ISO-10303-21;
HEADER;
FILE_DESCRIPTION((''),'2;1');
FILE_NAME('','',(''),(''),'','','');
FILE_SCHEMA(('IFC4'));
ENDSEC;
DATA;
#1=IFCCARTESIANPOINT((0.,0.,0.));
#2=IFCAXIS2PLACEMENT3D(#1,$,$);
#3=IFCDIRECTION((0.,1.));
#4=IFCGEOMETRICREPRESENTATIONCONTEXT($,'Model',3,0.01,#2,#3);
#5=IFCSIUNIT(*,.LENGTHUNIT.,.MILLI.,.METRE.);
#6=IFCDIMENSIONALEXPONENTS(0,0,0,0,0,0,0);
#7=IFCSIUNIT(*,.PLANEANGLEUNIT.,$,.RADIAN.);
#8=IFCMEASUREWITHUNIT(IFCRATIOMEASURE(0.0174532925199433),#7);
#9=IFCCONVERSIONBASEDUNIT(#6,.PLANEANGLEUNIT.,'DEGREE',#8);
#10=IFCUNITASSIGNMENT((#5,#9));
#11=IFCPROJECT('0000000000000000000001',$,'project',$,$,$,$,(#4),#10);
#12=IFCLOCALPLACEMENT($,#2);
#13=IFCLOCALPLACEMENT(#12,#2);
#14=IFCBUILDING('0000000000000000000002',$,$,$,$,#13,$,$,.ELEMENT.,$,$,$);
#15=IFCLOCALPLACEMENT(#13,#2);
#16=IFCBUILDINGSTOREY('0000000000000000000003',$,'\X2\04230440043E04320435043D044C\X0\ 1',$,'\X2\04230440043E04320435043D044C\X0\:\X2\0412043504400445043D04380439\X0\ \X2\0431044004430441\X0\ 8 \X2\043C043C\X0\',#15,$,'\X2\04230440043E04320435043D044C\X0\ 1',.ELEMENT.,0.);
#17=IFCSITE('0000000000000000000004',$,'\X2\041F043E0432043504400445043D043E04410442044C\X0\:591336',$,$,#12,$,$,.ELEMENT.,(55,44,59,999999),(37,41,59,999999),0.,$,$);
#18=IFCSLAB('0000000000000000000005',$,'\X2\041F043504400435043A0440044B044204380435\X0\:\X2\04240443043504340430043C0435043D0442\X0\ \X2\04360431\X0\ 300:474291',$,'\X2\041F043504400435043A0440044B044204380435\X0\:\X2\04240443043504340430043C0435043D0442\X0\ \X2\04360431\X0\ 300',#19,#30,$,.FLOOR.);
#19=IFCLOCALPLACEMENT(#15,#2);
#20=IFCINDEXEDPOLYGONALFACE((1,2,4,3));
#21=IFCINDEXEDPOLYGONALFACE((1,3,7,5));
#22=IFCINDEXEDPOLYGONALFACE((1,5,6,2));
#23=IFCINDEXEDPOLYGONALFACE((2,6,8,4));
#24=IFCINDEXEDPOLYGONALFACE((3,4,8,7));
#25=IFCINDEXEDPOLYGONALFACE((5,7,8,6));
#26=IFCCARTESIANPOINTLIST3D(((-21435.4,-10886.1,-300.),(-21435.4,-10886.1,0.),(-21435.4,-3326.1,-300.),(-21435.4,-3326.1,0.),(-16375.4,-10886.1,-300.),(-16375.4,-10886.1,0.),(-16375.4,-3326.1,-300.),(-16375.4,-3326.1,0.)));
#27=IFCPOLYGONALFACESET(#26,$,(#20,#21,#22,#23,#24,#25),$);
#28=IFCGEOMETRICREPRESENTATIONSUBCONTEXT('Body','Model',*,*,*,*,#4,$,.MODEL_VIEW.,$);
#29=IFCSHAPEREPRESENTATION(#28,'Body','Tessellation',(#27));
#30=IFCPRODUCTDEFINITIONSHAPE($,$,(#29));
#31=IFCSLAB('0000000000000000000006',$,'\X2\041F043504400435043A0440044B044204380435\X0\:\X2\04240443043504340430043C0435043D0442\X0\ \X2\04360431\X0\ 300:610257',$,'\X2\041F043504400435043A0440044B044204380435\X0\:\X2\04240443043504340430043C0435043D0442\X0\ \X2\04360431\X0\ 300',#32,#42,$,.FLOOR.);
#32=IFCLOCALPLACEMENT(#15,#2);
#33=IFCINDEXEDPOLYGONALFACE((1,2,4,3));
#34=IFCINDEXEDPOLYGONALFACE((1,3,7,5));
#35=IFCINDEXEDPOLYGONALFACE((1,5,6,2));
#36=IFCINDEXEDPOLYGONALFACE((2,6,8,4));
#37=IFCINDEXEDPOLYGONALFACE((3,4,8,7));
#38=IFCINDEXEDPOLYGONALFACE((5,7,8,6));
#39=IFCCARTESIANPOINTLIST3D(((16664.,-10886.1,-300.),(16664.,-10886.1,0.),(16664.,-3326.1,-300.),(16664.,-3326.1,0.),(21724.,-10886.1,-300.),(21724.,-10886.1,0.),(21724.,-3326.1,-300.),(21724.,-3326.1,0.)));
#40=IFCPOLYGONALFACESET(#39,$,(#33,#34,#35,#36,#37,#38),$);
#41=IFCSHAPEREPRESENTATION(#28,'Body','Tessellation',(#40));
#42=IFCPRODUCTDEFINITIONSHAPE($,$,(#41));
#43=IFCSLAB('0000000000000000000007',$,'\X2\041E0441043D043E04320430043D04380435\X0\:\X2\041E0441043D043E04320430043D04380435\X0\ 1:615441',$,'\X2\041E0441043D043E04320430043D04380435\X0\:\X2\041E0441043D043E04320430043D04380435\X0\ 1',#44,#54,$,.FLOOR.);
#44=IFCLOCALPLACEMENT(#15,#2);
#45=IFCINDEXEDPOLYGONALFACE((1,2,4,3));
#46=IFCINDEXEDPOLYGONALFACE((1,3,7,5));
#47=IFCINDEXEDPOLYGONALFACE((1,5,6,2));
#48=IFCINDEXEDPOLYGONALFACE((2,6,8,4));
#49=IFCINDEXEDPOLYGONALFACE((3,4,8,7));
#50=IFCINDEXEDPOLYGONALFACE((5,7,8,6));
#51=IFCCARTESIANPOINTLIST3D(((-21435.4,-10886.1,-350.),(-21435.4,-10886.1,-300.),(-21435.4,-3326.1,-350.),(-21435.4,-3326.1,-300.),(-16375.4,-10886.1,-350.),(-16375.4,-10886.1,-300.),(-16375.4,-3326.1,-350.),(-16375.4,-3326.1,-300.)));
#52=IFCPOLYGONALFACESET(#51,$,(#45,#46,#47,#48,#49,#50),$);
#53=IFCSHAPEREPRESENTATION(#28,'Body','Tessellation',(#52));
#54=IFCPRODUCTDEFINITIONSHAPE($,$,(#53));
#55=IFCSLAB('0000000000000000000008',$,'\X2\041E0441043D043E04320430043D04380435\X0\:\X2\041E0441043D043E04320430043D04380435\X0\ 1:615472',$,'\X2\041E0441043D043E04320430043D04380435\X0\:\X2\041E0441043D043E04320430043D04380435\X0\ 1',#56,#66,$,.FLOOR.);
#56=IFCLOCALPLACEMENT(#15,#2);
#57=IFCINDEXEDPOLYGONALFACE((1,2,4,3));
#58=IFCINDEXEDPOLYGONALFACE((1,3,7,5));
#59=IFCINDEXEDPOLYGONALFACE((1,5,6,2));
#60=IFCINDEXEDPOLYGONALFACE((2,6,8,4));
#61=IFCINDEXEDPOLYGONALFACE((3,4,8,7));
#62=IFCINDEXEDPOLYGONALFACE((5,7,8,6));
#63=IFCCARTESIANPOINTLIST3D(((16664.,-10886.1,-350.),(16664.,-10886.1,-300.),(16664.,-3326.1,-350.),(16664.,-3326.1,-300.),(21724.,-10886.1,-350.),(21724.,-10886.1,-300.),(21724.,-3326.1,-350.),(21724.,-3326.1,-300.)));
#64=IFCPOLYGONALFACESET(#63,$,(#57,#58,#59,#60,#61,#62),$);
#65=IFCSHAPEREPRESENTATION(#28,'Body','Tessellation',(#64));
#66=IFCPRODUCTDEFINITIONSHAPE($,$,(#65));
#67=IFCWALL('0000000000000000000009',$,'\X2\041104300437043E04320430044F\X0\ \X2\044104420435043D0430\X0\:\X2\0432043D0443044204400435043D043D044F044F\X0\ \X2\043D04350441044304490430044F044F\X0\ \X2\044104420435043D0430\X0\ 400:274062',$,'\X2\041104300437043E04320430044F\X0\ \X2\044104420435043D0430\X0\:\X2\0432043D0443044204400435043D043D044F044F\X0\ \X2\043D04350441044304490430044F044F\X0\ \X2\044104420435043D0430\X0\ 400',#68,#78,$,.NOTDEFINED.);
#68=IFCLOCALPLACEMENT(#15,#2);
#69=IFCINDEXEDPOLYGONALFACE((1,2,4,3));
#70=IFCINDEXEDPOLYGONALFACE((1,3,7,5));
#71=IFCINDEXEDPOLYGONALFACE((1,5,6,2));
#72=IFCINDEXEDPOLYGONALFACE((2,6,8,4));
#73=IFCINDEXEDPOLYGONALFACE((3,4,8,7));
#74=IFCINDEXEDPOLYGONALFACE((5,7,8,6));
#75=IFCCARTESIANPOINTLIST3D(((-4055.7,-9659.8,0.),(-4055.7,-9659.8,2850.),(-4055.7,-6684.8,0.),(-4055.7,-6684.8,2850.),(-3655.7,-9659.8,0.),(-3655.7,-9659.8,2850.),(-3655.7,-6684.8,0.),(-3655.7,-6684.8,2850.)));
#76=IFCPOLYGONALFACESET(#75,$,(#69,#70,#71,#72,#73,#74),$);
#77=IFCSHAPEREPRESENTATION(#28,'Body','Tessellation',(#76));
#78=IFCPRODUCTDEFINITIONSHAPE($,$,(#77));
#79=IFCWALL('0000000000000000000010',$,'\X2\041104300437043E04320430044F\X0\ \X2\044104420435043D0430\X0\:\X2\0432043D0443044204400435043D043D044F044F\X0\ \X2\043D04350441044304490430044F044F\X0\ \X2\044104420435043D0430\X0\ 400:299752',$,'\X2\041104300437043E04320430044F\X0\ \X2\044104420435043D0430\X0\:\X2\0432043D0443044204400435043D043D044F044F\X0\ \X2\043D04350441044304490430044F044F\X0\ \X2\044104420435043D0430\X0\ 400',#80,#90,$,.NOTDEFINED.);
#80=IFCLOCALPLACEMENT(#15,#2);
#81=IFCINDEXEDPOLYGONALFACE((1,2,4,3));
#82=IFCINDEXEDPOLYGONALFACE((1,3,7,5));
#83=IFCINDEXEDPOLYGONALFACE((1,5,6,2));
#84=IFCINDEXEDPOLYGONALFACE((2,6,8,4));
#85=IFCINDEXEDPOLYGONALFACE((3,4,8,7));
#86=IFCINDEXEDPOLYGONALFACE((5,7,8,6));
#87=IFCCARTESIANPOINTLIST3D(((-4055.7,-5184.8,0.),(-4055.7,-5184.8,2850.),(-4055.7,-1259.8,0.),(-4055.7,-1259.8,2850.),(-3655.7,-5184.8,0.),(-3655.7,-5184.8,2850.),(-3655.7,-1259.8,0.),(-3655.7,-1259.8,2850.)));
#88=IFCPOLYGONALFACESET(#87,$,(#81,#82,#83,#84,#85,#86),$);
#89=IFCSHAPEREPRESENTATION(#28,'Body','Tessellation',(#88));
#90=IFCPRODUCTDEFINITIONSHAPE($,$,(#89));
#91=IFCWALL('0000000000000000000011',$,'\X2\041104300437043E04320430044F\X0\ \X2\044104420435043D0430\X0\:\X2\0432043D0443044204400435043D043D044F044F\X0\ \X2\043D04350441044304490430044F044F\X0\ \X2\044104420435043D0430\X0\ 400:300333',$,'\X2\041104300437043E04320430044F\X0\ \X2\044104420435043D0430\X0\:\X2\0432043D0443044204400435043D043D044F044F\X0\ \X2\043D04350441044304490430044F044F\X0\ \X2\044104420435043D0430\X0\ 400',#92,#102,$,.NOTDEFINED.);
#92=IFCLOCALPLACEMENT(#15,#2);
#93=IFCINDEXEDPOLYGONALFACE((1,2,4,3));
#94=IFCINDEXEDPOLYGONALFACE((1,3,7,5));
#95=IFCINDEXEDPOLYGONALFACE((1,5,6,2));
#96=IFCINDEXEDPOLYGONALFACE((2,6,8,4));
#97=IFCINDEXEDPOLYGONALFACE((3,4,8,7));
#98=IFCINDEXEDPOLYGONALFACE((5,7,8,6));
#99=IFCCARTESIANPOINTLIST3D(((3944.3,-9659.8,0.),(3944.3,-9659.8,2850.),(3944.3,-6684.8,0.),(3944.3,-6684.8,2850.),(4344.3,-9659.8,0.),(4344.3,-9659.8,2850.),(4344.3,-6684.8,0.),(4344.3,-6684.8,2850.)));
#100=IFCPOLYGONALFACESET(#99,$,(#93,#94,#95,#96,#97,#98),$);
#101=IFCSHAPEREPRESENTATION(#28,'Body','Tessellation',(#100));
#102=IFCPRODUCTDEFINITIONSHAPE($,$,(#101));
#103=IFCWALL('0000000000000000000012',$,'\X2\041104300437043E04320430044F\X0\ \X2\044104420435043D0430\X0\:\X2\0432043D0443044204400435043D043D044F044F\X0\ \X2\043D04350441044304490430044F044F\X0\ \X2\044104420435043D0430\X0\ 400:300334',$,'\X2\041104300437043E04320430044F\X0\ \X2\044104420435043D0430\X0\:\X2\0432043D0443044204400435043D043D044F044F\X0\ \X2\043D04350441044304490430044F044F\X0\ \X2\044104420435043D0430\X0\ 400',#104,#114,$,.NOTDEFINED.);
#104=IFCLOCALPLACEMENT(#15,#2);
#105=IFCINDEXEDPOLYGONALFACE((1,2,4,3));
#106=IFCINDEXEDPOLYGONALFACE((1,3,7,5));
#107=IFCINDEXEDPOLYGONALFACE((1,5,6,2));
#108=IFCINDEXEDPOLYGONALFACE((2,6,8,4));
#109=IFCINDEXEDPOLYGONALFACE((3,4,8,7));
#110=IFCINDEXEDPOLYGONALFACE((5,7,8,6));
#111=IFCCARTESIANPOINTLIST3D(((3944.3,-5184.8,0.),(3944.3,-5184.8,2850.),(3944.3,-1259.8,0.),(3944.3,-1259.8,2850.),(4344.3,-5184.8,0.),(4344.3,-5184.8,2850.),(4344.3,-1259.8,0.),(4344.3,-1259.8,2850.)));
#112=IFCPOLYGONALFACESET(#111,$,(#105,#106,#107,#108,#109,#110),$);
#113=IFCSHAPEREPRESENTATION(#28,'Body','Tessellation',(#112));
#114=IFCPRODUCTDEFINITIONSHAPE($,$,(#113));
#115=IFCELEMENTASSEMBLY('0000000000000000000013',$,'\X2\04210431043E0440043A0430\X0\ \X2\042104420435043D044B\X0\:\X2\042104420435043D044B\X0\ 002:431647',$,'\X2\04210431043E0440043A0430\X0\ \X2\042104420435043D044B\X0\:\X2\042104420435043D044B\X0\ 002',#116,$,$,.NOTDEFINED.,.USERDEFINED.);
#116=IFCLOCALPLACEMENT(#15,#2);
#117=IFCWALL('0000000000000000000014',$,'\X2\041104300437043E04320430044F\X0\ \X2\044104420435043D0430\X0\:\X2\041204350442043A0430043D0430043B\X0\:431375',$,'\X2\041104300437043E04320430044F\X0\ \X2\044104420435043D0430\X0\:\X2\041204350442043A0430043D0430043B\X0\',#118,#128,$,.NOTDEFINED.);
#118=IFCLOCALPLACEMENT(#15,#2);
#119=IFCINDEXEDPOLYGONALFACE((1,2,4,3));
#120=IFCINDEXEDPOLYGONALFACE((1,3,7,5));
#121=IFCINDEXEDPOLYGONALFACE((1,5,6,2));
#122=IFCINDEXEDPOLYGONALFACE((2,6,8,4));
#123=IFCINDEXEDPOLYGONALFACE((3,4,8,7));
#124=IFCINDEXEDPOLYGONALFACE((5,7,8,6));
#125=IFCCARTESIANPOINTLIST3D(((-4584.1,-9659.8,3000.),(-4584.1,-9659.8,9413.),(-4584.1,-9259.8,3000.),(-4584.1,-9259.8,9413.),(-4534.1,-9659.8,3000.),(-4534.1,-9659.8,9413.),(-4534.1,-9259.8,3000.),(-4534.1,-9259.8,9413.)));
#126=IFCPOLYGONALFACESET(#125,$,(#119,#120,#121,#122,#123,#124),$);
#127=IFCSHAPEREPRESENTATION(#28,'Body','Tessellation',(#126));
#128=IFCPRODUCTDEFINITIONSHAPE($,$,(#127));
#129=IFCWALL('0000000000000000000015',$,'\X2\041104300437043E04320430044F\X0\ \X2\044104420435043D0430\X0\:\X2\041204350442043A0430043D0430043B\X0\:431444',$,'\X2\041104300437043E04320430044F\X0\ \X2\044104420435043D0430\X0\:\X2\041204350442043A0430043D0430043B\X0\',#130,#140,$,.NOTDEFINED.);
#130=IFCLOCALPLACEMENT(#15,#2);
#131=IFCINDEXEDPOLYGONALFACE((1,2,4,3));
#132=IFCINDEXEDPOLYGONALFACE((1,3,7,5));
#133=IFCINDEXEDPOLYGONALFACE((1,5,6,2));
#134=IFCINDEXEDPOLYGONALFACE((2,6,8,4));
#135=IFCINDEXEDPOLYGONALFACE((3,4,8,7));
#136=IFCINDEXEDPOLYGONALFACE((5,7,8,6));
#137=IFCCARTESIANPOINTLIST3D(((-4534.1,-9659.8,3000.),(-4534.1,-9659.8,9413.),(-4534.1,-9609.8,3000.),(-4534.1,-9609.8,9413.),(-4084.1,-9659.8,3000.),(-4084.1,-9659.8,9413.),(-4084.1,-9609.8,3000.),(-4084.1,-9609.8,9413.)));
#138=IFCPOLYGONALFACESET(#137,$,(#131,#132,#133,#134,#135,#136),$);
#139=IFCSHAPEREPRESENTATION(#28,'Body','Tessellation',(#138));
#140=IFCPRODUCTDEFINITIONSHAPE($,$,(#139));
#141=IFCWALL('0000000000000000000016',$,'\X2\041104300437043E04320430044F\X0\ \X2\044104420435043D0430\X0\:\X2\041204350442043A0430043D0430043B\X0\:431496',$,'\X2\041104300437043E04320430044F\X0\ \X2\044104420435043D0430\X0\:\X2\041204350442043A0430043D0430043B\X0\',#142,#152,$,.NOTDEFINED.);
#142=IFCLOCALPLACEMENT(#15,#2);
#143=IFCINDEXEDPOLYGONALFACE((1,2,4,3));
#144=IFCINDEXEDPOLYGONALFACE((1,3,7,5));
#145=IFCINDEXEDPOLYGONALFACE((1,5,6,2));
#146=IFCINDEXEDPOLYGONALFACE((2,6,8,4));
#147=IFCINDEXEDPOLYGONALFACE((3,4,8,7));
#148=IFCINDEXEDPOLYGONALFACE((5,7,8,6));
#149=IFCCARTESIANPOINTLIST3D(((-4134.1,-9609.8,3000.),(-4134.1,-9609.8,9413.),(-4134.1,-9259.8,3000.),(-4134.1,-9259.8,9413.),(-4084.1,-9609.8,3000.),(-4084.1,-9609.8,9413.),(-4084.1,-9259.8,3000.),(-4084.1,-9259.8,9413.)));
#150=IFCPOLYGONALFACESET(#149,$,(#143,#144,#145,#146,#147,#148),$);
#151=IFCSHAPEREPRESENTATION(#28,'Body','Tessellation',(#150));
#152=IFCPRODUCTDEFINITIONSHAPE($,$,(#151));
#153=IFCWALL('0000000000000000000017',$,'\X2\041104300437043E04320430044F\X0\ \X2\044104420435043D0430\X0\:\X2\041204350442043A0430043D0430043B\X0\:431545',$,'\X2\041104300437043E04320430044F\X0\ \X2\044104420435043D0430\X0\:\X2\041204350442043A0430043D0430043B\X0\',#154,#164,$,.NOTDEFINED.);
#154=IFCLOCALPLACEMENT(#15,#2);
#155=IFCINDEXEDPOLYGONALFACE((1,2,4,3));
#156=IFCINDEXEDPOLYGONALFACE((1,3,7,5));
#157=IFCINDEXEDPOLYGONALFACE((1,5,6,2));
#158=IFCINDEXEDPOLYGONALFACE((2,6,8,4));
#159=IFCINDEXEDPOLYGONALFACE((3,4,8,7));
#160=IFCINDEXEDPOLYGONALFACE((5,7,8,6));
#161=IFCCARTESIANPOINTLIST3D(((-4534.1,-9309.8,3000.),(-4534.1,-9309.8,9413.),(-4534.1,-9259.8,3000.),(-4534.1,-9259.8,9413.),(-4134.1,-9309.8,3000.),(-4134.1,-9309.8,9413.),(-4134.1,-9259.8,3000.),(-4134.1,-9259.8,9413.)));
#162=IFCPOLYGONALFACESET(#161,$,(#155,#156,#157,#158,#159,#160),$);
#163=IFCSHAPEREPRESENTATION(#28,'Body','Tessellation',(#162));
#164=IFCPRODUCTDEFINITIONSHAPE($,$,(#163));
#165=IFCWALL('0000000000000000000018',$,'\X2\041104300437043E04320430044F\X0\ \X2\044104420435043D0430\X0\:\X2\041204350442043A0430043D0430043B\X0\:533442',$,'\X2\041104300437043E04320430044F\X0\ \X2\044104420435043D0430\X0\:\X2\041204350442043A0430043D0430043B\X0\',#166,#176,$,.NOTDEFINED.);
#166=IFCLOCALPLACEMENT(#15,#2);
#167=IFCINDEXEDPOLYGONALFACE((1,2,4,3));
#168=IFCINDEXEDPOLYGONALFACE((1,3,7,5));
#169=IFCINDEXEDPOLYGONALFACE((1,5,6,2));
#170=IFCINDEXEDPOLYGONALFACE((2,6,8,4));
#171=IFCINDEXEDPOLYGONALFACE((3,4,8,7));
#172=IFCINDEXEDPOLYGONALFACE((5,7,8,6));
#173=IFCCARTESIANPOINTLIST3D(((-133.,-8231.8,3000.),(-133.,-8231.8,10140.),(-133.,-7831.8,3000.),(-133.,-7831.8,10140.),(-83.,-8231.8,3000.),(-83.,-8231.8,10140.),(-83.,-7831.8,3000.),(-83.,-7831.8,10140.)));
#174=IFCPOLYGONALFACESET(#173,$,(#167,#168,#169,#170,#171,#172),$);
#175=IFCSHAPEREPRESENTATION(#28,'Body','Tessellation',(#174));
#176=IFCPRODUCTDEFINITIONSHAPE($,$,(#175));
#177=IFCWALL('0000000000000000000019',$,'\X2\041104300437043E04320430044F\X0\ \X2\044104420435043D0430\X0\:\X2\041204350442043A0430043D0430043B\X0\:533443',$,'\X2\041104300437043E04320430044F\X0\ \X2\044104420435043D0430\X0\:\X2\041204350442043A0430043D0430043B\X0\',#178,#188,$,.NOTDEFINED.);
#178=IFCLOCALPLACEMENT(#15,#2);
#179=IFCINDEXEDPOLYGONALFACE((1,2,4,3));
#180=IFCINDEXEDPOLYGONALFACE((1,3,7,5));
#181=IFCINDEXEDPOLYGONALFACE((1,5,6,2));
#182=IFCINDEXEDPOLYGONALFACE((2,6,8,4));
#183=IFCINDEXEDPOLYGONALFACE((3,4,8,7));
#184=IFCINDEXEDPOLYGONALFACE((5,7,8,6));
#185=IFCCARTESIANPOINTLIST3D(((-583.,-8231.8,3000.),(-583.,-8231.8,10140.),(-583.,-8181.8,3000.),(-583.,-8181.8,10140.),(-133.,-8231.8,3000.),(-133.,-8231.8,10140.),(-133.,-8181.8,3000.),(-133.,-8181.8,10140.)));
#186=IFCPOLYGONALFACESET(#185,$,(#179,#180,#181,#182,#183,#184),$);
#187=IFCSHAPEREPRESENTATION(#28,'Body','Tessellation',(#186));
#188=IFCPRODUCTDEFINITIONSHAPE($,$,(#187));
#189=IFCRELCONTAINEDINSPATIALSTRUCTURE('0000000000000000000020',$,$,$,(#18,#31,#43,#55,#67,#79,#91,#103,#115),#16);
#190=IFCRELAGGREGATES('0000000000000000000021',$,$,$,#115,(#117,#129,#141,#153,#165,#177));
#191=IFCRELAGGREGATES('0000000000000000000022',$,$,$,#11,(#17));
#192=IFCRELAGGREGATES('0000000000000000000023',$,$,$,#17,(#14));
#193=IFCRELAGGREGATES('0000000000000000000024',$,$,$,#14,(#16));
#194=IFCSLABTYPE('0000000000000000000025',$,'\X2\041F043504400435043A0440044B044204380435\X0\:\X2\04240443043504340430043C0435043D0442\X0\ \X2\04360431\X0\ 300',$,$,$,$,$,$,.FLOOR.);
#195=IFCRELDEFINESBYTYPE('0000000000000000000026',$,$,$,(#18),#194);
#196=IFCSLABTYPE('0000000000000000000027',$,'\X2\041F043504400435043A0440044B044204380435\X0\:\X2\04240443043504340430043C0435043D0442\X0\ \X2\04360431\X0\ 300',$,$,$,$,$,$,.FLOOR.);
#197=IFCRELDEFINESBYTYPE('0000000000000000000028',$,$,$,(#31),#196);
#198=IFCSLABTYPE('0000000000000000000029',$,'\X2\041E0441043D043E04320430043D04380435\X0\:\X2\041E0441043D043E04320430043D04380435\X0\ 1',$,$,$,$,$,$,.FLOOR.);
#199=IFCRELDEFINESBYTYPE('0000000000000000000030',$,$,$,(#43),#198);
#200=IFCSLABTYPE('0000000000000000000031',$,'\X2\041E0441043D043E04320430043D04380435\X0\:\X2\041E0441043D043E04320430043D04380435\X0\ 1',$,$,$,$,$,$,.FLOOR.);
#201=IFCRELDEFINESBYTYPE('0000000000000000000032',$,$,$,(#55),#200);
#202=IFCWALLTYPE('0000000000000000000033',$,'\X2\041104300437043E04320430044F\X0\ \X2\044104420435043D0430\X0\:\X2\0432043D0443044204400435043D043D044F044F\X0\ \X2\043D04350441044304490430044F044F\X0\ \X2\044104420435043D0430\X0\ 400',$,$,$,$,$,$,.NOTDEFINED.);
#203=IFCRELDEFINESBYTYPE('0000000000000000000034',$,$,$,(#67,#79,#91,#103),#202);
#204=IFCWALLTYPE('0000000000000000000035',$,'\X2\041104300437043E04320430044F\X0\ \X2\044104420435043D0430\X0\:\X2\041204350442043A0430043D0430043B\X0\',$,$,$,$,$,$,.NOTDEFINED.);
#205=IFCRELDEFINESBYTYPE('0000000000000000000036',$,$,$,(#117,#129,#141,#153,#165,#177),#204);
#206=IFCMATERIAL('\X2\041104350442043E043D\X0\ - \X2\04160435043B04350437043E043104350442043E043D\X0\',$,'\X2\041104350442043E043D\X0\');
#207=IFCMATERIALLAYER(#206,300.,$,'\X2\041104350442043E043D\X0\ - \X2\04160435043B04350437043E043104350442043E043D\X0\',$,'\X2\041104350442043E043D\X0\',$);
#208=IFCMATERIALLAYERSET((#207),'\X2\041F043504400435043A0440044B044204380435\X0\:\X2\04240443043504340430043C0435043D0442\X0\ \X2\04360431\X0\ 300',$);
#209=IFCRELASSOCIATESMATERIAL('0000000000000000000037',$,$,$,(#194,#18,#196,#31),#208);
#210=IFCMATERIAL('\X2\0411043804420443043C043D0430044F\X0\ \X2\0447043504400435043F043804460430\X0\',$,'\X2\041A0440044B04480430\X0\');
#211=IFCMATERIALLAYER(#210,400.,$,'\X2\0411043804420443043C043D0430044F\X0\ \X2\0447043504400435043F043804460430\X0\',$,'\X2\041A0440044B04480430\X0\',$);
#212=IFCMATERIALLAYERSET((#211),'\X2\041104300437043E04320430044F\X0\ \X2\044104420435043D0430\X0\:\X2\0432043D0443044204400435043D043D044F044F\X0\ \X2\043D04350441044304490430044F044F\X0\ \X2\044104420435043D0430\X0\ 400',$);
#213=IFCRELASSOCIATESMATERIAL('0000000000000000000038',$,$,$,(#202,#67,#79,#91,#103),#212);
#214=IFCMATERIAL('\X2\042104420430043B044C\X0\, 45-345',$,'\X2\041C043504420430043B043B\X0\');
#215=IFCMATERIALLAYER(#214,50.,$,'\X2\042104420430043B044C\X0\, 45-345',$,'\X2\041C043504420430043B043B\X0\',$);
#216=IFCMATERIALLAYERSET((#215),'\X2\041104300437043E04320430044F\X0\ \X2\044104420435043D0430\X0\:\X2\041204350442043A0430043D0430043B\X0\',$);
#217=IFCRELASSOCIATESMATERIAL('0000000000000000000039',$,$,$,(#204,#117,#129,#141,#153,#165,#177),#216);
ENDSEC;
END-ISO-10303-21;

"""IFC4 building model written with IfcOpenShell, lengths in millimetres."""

from ifc_helpers import new_model, entity, si_unit, converted_unit, direction, frame, origin, place, context, subcontext, project, spatial, indexed_curve, outline, extrude, material, layer, layer_set, type_object, element, aggregate, save


model = new_model("IFC4")

# Units and contexts
model_context = context("Model", 3, precision=0.01, world=origin(), true_north=direction((0.0, 1.0)))
body_context = subcontext(model_context, "Body", "Model", "MODEL_VIEW")
ifc_project = project(units=[si_unit("LENGTHUNIT", "METRE", prefix="MILLI"), converted_unit("PLANEANGLEUNIT", "DEGREE", entity("IfcRatioMeasure", 0.0174532925199433), si_unit("PLANEANGLEUNIT", "RADIAN"), dimensions=[0, 0, 0, 0, 0, 0, 0])], contexts=[model_context])

# Site, building, storey
site_placement = place(None, origin())
site = spatial("IfcSite", under=ifc_project, at=site_placement, Name="Поверхность:591336", CompositionType="ELEMENT", RefLatitude=(55, 44, 59, 999999), RefLongitude=(37, 41, 59, 999999), RefElevation=0.0)
building_placement = place(site_placement, origin())
building = spatial("IfcBuilding", under=site, at=building_placement, CompositionType="ELEMENT")
storey_placement = place(building_placement, origin())
storey = spatial("IfcBuildingStorey", under=building, at=storey_placement, Name="Уровень 1", ObjectType="Уровень:Верхний брус 8 мм", LongName="Уровень 1", CompositionType="ELEMENT", Elevation=0.0)

# Slabs
ifc_material_1 = material(Name="Бетон - Железобетон", Category="Бетон")
ifc_layer_1 = layer(ifc_material_1, 300.0, Name="Бетон - Железобетон", Category="Бетон")
ifc_layer_set_1 = layer_set([ifc_layer_1], Name="Перекрытие:Фуедамент жб 300")
slab_type_1 = type_object("IfcSlabType", Name="Перекрытие:Фуедамент жб 300", PredefinedType="FLOOR", material=ifc_layer_set_1)
slab_1_placement = place(storey_placement, origin())
element("IfcSlab", 1, at=slab_1_placement, inside=storey, type_object=slab_type_1, material=ifc_layer_set_1, Name="Перекрытие:Фуедамент жб 300:474291", ObjectType="Перекрытие:Фуедамент жб 300", PredefinedType="FLOOR", context=body_context, shape_type="SweptSolid", body=[
    extrude(outline(indexed_curve([(-3780.0, -2530.0), (3780.0, -2530.0), (3780.0, 2530.0), (-3780.0, 2530.0), (-3780.0, -2530.0)], self_intersect=False)), frame((-18905.4, -7106.1, 0.0), z_axis=(0.0, 0.0, -1.0), x_axis=(0.0, 1.0, 0.0)), (0.0, 0.0, 1.0), 300.0),
])
slab_type_2 = type_object("IfcSlabType", Name="Перекрытие:Фуедамент жб 300", PredefinedType="FLOOR", material=ifc_layer_set_1)
slab_2_placement = place(storey_placement, origin())
element("IfcSlab", 2, at=slab_2_placement, inside=storey, type_object=slab_type_2, material=ifc_layer_set_1, Name="Перекрытие:Фуедамент жб 300:610257", ObjectType="Перекрытие:Фуедамент жб 300", PredefinedType="FLOOR", context=body_context, shape_type="SweptSolid", body=[
    extrude(outline(indexed_curve([(-3780.0, -2530.0), (3780.0, -2530.0), (3780.0, 2530.0), (-3780.0, 2530.0), (-3780.0, -2530.0)], self_intersect=False)), frame((19194.0, -7106.1, 0.0), z_axis=(0.0, 0.0, -1.0), x_axis=(0.0, 1.0, 0.0)), (0.0, 0.0, 1.0), 300.0),
])
slab_type_3 = type_object("IfcSlabType", Name="Основание:Основание 1", PredefinedType="FLOOR")
slab_3_placement = place(storey_placement, origin())
element("IfcSlab", 3, at=slab_3_placement, inside=storey, type_object=slab_type_3, Name="Основание:Основание 1:615441", ObjectType="Основание:Основание 1", PredefinedType="FLOOR", context=body_context, shape_type="SweptSolid", body=[
    extrude(outline(indexed_curve([(-3780.0, -2530.0), (3780.0, -2530.0), (3780.0, 2530.0), (-3780.0, 2530.0), (-3780.0, -2530.0)], self_intersect=False)), frame((-18905.4, -7106.1, -350.0), z_axis=(0.0, 0.0, 1.0), x_axis=(0.0, 1.0, 0.0)), (0.0, 0.0, 1.0), 50.0),
])
slab_type_4 = type_object("IfcSlabType", Name="Основание:Основание 1", PredefinedType="FLOOR")
slab_4_placement = place(storey_placement, origin())
element("IfcSlab", 4, at=slab_4_placement, inside=storey, type_object=slab_type_4, Name="Основание:Основание 1:615472", ObjectType="Основание:Основание 1", PredefinedType="FLOOR", context=body_context, shape_type="SweptSolid", body=[
    extrude(outline(indexed_curve([(-2530.0, -3780.0), (2530.0, -3780.0), (2530.0, 3780.0), (-2530.0, 3780.0), (-2530.0, -3780.0)], self_intersect=False)), frame((19194.0, -7106.1, -350.0), z_axis=(0.0, 0.0, 1.0), x_axis=(-1.0, 0.0, 0.0)), (0.0, 0.0, 1.0), 50.0),
])

# Walls
ifc_material_2 = material(Name="Битумная черепица", Category="Крыша")
ifc_layer_2 = layer(ifc_material_2, 400.0, Name="Битумная черепица", Category="Крыша")
ifc_layer_set_2 = layer_set([ifc_layer_2], Name="Базовая стена:внутренняя несущаяя стена 400")
wall_type_1 = type_object("IfcWallType", Name="Базовая стена:внутренняя несущаяя стена 400", PredefinedType="NOTDEFINED", material=ifc_layer_set_2)
wall_1_placement = place(storey_placement, frame((-3855.7, -9659.8, 0.0), z_axis=(0.0, 0.0, 1.0), x_axis=(0.0, 1.0, 0.0)))
element("IfcWall", 5, at=wall_1_placement, inside=storey, type_object=wall_type_1, material=ifc_layer_set_2, Name="Базовая стена:внутренняя несущаяя стена 400:274062", ObjectType="Базовая стена:внутренняя несущаяя стена 400", PredefinedType="NOTDEFINED", context=body_context, shape_type="SweptSolid", body=[
    extrude(outline(indexed_curve([(2975.0, 200.0), (0.0, 200.0), (0.0, -200.0), (2975.0, -200.0), (2975.0, 200.0)], self_intersect=False)), origin(), (0.0, 0.0, 1.0), 2850.0),
])
wall_2_placement = place(storey_placement, frame((-3855.7, -5184.8, 0.0), z_axis=(0.0, 0.0, 1.0), x_axis=(0.0, 1.0, 0.0)))
element("IfcWall", 6, at=wall_2_placement, inside=storey, type_object=wall_type_1, material=ifc_layer_set_2, Name="Базовая стена:внутренняя несущаяя стена 400:299752", ObjectType="Базовая стена:внутренняя несущаяя стена 400", PredefinedType="NOTDEFINED", context=body_context, shape_type="SweptSolid", body=[
    extrude(outline(indexed_curve([(3925.0, 200.0), (0.0, 200.0), (0.0, -200.0), (3925.0, -200.0), (3925.0, 200.0)], self_intersect=False)), origin(), (0.0, 0.0, 1.0), 2850.0),
])
wall_3_placement = place(storey_placement, frame((4144.3, -9659.8, 0.0), z_axis=(0.0, 0.0, 1.0), x_axis=(0.0, 1.0, 0.0)))
element("IfcWall", 7, at=wall_3_placement, inside=storey, type_object=wall_type_1, material=ifc_layer_set_2, Name="Базовая стена:внутренняя несущаяя стена 400:300333", ObjectType="Базовая стена:внутренняя несущаяя стена 400", PredefinedType="NOTDEFINED", context=body_context, shape_type="SweptSolid", body=[
    extrude(outline(indexed_curve([(2975.0, 200.0), (0.0, 200.0), (0.0, -200.0), (2975.0, -200.0), (2975.0, 200.0)], self_intersect=False)), origin(), (0.0, 0.0, 1.0), 2850.0),
])
wall_4_placement = place(storey_placement, frame((4144.3, -5184.8, 0.0), z_axis=(0.0, 0.0, 1.0), x_axis=(0.0, 1.0, 0.0)))
element("IfcWall", 8, at=wall_4_placement, inside=storey, type_object=wall_type_1, material=ifc_layer_set_2, Name="Базовая стена:внутренняя несущаяя стена 400:300334", ObjectType="Базовая стена:внутренняя несущаяя стена 400", PredefinedType="NOTDEFINED", context=body_context, shape_type="SweptSolid", body=[
    extrude(outline(indexed_curve([(3925.0, 200.0), (0.0, 200.0), (0.0, -200.0), (3925.0, -200.0), (3925.0, 200.0)], self_intersect=False)), origin(), (0.0, 0.0, 1.0), 2850.0),
])

# Element assembly, walls
assembly_placement = place(storey_placement, origin())
assembly = element("IfcElementAssembly", 9, at=assembly_placement, inside=storey, Name="Сборка Стены:Стены 002:431647", ObjectType="Сборка Стены:Стены 002", AssemblyPlace="NOTDEFINED", PredefinedType="USERDEFINED")
ifc_material_3 = material(Name="Сталь, 45-345", Category="Металл")
ifc_layer_3 = layer(ifc_material_3, 50.0, Name="Сталь, 45-345", Category="Металл")
ifc_layer_set_3 = layer_set([ifc_layer_3], Name="Базовая стена:Ветканал")
wall_type_2 = type_object("IfcWallType", Name="Базовая стена:Ветканал", PredefinedType="NOTDEFINED", material=ifc_layer_set_3)
wall_5_placement = place(assembly_placement, frame((-4559.1, -9259.8, 3000.0), z_axis=(0.0, 0.0, 1.0), x_axis=(0.0, -1.0, 0.0)))
wall_5 = element("IfcWall", 10, at=wall_5_placement, type_object=wall_type_2, material=ifc_layer_set_3, Name="Базовая стена:Ветканал:431375", ObjectType="Базовая стена:Ветканал", PredefinedType="NOTDEFINED", context=body_context, shape_type="SweptSolid", body=[
    extrude(outline(indexed_curve([(400.0, 25.0), (0.0, 25.0), (0.0, -25.0), (400.0, -25.0), (400.0, 25.0)], self_intersect=False)), origin(), (0.0, 0.0, 1.0), 6413.0),
])
wall_6_placement = place(assembly_placement, frame((-4534.1, -9634.8, 3000.0)))
wall_6 = element("IfcWall", 11, at=wall_6_placement, type_object=wall_type_2, material=ifc_layer_set_3, Name="Базовая стена:Ветканал:431444", ObjectType="Базовая стена:Ветканал", PredefinedType="NOTDEFINED", context=body_context, shape_type="SweptSolid", body=[
    extrude(outline(indexed_curve([(450.0, 25.0), (0.0, 25.0), (0.0, -25.0), (450.0, -25.0), (450.0, 25.0)], self_intersect=False)), origin(), (0.0, 0.0, 1.0), 6413.0),
])
wall_7_placement = place(assembly_placement, frame((-4109.1, -9609.8, 3000.0), z_axis=(0.0, 0.0, 1.0), x_axis=(0.0, 1.0, 0.0)))
wall_7 = element("IfcWall", 12, at=wall_7_placement, type_object=wall_type_2, material=ifc_layer_set_3, Name="Базовая стена:Ветканал:431496", ObjectType="Базовая стена:Ветканал", PredefinedType="NOTDEFINED", context=body_context, shape_type="SweptSolid", body=[
    extrude(outline(indexed_curve([(350.0, 25.0), (0.0, 25.0), (0.0, -25.0), (350.0, -25.0), (350.0, 25.0)], self_intersect=False)), origin(), (0.0, 0.0, 1.0), 6413.0),
])
wall_8_placement = place(assembly_placement, frame((-4134.1, -9284.8, 3000.0), z_axis=(0.0, 0.0, 1.0), x_axis=(-1.0, 0.0, 0.0)))
wall_8 = element("IfcWall", 13, at=wall_8_placement, type_object=wall_type_2, material=ifc_layer_set_3, Name="Базовая стена:Ветканал:431545", ObjectType="Базовая стена:Ветканал", PredefinedType="NOTDEFINED", context=body_context, shape_type="SweptSolid", body=[
    extrude(outline(indexed_curve([(400.0, 25.0), (0.0, 25.0), (0.0, -25.0), (400.0, -25.0), (400.0, 25.0)], self_intersect=False)), origin(), (0.0, 0.0, 1.0), 6413.0),
])
wall_9_placement = place(assembly_placement, frame((-108.0, -7831.8, 3000.0), z_axis=(0.0, 0.0, 1.0), x_axis=(0.0, -1.0, 0.0)))
wall_9 = element("IfcWall", 14, at=wall_9_placement, type_object=wall_type_2, material=ifc_layer_set_3, Name="Базовая стена:Ветканал:533442", ObjectType="Базовая стена:Ветканал", PredefinedType="NOTDEFINED", context=body_context, shape_type="SweptSolid", body=[
    extrude(outline(indexed_curve([(400.0, 25.0), (0.0, 25.0), (0.0, -25.0), (400.0, -25.0), (400.0, 25.0)], self_intersect=False)), origin(), (0.0, 0.0, 1.0), 7140.0),
])
wall_10_placement = place(assembly_placement, frame((-133.0, -8206.8, 3000.0), z_axis=(0.0, 0.0, 1.0), x_axis=(-1.0, 0.0, 0.0)))
wall_10 = element("IfcWall", 15, at=wall_10_placement, type_object=wall_type_2, material=ifc_layer_set_3, Name="Базовая стена:Ветканал:533443", ObjectType="Базовая стена:Ветканал", PredefinedType="NOTDEFINED", context=body_context, shape_type="SweptSolid", body=[
    extrude(outline(indexed_curve([(450.0, 25.0), (0.0, 25.0), (0.0, -25.0), (450.0, -25.0), (450.0, 25.0)], self_intersect=False)), origin(), (0.0, 0.0, 1.0), 7140.0),
])
aggregate(assembly, [wall_5, wall_6, wall_7, wall_8, wall_9, wall_10])

save(model, "model.ifc")
